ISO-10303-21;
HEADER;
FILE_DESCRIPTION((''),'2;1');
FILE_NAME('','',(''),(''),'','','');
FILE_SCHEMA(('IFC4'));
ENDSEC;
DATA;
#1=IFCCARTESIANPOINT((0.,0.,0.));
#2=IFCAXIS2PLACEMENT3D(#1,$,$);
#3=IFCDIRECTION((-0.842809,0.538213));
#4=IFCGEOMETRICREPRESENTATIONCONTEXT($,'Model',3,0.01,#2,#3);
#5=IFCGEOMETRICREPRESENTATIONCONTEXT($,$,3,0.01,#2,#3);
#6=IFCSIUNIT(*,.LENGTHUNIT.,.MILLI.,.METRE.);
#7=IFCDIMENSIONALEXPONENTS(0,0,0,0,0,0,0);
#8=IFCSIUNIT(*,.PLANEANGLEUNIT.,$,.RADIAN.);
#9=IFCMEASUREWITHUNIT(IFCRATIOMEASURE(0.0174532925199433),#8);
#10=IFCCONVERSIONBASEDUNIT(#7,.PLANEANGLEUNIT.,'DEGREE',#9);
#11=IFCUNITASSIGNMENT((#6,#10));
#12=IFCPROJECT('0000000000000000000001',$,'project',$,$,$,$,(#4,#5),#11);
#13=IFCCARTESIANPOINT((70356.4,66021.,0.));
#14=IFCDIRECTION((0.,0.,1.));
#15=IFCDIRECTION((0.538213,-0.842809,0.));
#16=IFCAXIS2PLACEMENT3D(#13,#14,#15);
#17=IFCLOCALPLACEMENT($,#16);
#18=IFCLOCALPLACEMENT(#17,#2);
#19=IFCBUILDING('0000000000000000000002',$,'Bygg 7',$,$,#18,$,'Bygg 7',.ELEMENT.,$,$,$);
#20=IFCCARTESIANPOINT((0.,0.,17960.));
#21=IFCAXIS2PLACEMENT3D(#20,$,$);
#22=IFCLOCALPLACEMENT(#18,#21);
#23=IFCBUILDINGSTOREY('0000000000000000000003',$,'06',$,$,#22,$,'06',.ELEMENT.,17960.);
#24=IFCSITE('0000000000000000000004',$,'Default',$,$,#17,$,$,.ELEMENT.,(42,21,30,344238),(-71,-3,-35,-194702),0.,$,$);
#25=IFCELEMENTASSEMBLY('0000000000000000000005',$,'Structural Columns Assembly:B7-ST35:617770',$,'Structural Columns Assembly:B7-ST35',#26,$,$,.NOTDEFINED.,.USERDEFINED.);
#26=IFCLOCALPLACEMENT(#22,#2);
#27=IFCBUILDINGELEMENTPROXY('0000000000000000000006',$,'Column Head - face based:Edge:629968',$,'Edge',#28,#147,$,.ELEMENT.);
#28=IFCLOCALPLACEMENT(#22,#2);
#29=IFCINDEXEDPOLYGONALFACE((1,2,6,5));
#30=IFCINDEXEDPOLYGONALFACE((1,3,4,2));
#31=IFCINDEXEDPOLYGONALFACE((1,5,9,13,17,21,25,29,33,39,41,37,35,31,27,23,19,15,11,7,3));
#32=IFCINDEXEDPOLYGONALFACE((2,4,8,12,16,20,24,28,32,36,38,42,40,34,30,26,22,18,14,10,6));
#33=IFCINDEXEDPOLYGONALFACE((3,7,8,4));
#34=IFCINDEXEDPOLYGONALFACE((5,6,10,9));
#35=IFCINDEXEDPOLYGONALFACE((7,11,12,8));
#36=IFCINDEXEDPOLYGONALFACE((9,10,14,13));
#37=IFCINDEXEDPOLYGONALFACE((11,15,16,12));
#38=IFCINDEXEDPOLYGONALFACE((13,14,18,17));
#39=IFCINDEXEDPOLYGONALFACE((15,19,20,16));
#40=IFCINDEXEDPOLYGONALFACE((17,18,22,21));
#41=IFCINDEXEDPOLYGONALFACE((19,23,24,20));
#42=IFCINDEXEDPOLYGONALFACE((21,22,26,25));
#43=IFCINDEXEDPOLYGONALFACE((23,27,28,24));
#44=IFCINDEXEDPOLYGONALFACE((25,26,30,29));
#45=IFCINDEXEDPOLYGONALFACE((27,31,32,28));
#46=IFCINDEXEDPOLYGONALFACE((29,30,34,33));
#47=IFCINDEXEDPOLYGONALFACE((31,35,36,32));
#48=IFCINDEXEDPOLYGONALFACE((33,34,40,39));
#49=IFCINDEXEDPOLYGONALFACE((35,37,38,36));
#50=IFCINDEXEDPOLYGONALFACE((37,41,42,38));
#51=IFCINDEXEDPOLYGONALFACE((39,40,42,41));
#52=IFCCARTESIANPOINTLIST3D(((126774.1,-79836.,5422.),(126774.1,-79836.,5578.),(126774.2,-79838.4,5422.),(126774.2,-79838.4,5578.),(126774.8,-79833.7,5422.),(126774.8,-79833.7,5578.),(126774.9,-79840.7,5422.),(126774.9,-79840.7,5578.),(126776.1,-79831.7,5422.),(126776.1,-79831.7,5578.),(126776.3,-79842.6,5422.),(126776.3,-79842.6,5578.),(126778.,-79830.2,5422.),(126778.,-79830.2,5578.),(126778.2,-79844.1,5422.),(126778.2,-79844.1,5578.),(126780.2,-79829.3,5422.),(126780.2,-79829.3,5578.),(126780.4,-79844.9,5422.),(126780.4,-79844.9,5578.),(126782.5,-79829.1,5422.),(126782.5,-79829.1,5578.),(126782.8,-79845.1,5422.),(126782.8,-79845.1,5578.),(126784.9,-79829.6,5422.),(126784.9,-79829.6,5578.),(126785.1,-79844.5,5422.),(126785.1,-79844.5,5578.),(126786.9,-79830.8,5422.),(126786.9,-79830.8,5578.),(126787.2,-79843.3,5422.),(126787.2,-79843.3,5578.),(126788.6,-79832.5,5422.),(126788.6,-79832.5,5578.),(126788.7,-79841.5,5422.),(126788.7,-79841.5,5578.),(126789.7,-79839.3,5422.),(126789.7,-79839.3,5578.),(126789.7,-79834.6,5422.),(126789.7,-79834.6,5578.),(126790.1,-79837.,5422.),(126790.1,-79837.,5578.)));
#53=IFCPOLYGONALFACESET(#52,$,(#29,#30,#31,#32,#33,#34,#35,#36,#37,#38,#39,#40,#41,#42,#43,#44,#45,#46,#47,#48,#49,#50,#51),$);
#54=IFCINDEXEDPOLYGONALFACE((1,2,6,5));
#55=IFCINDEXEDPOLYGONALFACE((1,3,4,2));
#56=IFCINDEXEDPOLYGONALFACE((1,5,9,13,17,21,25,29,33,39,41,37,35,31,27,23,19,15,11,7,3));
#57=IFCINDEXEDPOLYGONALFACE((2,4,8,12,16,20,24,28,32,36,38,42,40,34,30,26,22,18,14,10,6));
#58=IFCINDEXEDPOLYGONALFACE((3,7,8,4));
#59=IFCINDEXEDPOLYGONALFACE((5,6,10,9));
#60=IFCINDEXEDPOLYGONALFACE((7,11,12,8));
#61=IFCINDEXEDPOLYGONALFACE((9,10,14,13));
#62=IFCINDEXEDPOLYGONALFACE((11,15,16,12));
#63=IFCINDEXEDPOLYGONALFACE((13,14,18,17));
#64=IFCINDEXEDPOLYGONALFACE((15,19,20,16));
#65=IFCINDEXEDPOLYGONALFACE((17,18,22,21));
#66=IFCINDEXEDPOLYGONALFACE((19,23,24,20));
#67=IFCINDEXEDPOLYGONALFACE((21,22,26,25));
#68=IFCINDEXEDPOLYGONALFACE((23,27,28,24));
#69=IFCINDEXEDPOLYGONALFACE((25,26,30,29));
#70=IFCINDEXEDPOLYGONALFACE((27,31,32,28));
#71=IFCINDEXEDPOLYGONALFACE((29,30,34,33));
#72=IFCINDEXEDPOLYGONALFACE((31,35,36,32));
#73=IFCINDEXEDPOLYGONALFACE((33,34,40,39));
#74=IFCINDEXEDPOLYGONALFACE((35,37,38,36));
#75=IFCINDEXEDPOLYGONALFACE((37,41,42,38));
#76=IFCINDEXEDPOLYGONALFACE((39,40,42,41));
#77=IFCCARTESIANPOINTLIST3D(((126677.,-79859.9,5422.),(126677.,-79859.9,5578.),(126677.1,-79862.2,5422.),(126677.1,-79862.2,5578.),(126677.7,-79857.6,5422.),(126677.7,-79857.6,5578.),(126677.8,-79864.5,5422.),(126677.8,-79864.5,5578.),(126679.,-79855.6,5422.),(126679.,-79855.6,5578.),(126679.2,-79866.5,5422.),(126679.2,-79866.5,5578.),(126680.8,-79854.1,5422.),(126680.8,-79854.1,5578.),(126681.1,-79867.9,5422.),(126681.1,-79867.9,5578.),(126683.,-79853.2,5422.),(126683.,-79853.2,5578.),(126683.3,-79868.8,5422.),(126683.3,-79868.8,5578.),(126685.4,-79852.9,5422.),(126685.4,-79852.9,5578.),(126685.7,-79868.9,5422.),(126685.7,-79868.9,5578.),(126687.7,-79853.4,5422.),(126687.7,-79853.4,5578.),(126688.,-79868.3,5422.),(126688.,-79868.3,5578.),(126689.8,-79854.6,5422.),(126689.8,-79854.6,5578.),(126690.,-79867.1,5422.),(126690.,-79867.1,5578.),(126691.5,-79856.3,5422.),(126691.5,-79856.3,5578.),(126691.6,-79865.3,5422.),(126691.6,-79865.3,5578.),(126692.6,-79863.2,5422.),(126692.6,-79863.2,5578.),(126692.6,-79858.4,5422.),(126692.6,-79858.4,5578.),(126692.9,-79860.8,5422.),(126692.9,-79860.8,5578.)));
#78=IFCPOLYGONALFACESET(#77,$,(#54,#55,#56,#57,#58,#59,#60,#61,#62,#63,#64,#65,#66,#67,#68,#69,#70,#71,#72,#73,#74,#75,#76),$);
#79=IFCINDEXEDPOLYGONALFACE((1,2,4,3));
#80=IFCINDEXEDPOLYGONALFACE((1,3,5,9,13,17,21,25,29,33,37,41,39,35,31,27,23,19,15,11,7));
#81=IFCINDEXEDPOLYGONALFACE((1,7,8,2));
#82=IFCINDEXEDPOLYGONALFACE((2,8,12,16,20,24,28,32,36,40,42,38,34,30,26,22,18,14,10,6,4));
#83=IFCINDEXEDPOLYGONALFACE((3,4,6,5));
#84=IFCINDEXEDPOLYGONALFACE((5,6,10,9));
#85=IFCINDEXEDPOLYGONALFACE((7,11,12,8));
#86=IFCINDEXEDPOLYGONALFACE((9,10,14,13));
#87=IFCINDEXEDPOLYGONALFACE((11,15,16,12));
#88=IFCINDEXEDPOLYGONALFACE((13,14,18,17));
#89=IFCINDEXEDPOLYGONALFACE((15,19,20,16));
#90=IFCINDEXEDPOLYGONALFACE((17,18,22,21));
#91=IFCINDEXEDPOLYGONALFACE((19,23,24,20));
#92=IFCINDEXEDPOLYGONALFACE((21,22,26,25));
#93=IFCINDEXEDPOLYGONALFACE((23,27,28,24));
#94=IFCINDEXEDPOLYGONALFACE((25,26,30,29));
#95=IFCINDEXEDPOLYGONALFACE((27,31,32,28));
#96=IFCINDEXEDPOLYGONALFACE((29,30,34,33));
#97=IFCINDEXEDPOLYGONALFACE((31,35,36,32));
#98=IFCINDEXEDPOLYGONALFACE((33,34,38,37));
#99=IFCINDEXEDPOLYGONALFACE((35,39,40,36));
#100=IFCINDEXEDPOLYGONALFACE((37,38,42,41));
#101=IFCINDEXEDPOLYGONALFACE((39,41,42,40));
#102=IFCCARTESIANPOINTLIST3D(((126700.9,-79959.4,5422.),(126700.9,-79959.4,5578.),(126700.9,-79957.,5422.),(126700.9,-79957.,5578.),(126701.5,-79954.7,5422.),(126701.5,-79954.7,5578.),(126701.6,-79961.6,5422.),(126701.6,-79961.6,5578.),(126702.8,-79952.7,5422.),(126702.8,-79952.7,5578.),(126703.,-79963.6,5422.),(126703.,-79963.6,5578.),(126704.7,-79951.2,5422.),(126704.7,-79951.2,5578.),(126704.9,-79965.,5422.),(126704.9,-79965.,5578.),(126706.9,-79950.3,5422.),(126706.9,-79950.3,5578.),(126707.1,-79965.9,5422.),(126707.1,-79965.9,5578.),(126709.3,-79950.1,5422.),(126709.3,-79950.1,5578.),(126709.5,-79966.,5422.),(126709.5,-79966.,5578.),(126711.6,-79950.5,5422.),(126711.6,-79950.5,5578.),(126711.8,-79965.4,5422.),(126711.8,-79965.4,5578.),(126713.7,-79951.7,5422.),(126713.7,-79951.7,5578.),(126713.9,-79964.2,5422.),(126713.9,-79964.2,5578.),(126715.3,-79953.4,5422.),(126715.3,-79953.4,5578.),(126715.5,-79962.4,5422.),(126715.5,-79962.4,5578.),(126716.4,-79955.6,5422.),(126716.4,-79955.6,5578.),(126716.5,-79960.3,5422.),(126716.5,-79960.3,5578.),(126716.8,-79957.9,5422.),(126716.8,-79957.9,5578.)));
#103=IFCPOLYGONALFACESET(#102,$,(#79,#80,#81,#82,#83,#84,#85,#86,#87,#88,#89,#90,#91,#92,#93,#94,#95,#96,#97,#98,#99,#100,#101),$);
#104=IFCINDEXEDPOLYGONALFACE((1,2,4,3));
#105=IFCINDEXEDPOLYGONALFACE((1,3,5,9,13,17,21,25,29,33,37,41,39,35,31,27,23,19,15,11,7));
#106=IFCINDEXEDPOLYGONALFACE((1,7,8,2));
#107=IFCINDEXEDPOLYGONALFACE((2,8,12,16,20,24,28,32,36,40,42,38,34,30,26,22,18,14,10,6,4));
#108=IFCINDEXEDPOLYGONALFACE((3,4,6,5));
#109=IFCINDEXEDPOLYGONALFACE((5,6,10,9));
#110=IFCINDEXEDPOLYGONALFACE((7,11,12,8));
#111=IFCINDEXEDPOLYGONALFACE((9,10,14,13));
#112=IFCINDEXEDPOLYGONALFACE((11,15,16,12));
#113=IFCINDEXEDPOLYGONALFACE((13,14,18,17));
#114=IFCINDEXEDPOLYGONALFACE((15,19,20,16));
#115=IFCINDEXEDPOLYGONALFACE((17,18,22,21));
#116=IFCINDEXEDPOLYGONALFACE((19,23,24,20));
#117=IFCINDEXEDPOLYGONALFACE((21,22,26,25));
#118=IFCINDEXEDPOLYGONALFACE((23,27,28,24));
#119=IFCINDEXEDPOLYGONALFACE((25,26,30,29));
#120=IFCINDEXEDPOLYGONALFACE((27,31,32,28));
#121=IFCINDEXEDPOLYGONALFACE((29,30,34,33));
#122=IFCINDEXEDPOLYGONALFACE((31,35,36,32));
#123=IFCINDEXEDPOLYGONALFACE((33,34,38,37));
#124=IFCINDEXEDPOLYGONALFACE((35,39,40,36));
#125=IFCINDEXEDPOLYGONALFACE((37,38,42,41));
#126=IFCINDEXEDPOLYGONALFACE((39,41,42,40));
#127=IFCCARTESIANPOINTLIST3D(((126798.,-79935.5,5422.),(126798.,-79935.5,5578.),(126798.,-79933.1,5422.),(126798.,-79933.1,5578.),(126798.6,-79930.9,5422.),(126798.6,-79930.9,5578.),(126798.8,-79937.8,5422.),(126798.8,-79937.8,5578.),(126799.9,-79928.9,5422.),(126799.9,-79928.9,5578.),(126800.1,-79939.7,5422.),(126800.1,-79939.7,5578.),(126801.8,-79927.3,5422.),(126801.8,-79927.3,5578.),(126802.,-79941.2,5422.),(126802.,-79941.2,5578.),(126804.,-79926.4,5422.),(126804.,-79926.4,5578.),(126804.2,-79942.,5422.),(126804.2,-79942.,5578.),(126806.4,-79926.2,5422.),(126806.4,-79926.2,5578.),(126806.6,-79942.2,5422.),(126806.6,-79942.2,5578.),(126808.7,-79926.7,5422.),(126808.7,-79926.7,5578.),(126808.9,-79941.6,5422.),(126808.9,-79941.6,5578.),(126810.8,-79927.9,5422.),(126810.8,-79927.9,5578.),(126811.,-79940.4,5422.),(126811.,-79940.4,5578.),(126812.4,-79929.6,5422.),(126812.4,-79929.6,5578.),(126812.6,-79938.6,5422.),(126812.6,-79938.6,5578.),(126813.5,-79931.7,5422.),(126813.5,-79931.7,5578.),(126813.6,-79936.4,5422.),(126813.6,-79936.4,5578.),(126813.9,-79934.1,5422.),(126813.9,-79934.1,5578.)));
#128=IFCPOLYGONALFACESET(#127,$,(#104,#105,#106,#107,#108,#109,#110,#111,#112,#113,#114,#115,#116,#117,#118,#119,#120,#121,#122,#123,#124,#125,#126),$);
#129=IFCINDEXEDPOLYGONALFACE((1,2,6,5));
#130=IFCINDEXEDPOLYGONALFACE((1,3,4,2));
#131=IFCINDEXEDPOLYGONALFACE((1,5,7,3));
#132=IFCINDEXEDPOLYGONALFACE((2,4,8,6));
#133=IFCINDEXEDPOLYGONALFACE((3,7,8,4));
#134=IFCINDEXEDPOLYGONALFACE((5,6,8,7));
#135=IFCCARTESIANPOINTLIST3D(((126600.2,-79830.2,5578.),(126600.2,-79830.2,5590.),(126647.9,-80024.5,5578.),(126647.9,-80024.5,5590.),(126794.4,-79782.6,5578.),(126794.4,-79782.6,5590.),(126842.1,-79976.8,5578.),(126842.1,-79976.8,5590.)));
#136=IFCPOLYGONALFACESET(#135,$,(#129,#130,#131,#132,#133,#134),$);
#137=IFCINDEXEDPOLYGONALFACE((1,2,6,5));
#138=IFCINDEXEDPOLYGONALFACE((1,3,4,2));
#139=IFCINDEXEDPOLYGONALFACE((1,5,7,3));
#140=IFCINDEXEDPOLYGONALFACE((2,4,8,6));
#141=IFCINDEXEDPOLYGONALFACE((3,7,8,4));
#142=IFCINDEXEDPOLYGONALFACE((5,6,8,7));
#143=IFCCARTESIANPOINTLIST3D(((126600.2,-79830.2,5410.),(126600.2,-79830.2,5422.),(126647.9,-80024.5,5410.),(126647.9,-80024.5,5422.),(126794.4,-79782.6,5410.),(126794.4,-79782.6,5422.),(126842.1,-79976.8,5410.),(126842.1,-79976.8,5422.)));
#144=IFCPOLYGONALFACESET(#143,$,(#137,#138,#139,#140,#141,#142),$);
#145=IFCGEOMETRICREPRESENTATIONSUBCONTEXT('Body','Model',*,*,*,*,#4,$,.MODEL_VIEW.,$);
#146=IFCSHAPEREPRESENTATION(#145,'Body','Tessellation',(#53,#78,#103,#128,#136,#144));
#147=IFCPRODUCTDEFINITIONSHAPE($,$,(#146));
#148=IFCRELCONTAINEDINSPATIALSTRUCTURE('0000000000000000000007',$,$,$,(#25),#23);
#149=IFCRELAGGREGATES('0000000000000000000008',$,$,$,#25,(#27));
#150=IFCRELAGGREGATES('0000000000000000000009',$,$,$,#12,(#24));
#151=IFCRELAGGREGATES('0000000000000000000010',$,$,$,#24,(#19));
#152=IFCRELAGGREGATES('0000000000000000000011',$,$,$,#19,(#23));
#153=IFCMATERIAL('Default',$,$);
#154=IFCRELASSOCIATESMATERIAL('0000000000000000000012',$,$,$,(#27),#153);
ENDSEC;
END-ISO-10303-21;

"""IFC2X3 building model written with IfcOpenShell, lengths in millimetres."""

from ifc_helpers import new_model, entity, si_unit, converted_unit, direction, frame, frame_2d, origin, origin_2d_with_axis, place, context, subcontext, project, spatial, rectangle, circle, extrude, source, transform, mapped, material, element, aggregate, save


model = new_model("IFC2X3")

# Units and contexts
model_context = context("Model", 3, precision=0.01, world=origin(), true_north=direction((-0.842809, 0.538213)))
context_of_model = context(None, 3, precision=0.01, world=origin(), true_north=direction((-0.842809, 0.538213)))
body_context = subcontext(model_context, "Body", "Model", "MODEL_VIEW")
ifc_project = project(units=[si_unit("LENGTHUNIT", "METRE", prefix="MILLI"), converted_unit("PLANEANGLEUNIT", "DEGREE", entity("IfcRatioMeasure", 0.0174532925199433), si_unit("PLANEANGLEUNIT", "RADIAN"), dimensions=[0, 0, 0, 0, 0, 0, 0])], contexts=[model_context, context_of_model])

# Site, building, storey
site_placement = place(None, frame((70356.4, 66021.0, 0.0), z_axis=(0.0, 0.0, 1.0), x_axis=(0.538213, -0.842809, 0.0)))
site = spatial("IfcSite", under=ifc_project, at=site_placement, Name="Default", CompositionType="ELEMENT", RefLatitude=(42, 21, 30, 344238), RefLongitude=(-71, -3, -35, -194702), RefElevation=0.0)
building_placement = place(site_placement, origin())
building = spatial("IfcBuilding", under=site, at=building_placement, Name="Bygg 7", LongName="Bygg 7", CompositionType="ELEMENT")
storey_placement = place(building_placement, frame((0.0, 0.0, 17960.0)))
storey = spatial("IfcBuildingStorey", under=building, at=storey_placement, Name="06", LongName="06", CompositionType="ELEMENT", Elevation=17960.0)

# Element assembly
assembly_1_placement = place(storey_placement, origin())
assembly_1 = element("IfcElementAssembly", 1, at=assembly_1_placement, inside=storey, Name="Structural Columns Assembly:B7-ST35:617770", ObjectType="Structural Columns Assembly:B7-ST35", AssemblyPlace="NOTDEFINED", PredefinedType="USERDEFINED")

# Building element proxy
ifc_material_1 = material(Name="Default")
shared_shape_1 = source(origin(), body_context, "Body", "SweptSolid", [
    extrude(circle(Radius=8.0, at=frame_2d((0.0, 0.0), x_axis=(1.0, 0.0))), frame((50.0, -135.0, 12.0)), (0.0, 0.0, 1.0), 156.0),
    extrude(circle(Radius=8.0, at=frame_2d((0.0, 0.0), x_axis=(1.0, 0.0))), frame((50.0, -35.0, 12.0)), (0.0, 0.0, 1.0), 156.0),
    extrude(circle(Radius=8.0, at=frame_2d((0.0, 0.0), x_axis=(1.0, 0.0))), frame((-50.0, -35.0, 12.0)), (0.0, 0.0, 1.0), 156.0),
    extrude(circle(Radius=8.0, at=frame_2d((0.0, 0.0), x_axis=(1.0, 0.0))), frame((-50.0, -135.0, 12.0)), (0.0, 0.0, 1.0), 156.0),
    extrude(rectangle(XDim=200.0, YDim=200.0, at=origin_2d_with_axis()), frame((0.0, -60.0, 168.0), z_axis=(0.0, 0.0, 1.0), x_axis=(-1.0, 0.0, 0.0)), (0.0, 0.0, 1.0), 12.0),
    extrude(rectangle(XDim=200.0, YDim=200.0, at=origin_2d_with_axis()), frame((0.0, -60.0, 0.0), z_axis=(0.0, 0.0, 1.0), x_axis=(0.0, 1.0, 0.0)), (0.0, 0.0, 1.0), 12.0),
])
proxy_1_placement = place(assembly_1_placement, frame((126662.9, -79917.8, 5410.0), z_axis=(0.0, 0.0, 1.0), x_axis=(-0.238381, 0.971172, 0.0)))
proxy_1 = element("IfcBuildingElementProxy", 2, at=proxy_1_placement, material=ifc_material_1, Name="Column Head - face based:Edge:629968", ObjectType="Edge", CompositionType="ELEMENT", context=body_context, shape_type="MappedRepresentation", body=[
    mapped(shared_shape_1, transform((0.0, 0.0, 0.0), scale=1.0)),
])
aggregate(assembly_1, [proxy_1])

save(model, "model.ifc")
